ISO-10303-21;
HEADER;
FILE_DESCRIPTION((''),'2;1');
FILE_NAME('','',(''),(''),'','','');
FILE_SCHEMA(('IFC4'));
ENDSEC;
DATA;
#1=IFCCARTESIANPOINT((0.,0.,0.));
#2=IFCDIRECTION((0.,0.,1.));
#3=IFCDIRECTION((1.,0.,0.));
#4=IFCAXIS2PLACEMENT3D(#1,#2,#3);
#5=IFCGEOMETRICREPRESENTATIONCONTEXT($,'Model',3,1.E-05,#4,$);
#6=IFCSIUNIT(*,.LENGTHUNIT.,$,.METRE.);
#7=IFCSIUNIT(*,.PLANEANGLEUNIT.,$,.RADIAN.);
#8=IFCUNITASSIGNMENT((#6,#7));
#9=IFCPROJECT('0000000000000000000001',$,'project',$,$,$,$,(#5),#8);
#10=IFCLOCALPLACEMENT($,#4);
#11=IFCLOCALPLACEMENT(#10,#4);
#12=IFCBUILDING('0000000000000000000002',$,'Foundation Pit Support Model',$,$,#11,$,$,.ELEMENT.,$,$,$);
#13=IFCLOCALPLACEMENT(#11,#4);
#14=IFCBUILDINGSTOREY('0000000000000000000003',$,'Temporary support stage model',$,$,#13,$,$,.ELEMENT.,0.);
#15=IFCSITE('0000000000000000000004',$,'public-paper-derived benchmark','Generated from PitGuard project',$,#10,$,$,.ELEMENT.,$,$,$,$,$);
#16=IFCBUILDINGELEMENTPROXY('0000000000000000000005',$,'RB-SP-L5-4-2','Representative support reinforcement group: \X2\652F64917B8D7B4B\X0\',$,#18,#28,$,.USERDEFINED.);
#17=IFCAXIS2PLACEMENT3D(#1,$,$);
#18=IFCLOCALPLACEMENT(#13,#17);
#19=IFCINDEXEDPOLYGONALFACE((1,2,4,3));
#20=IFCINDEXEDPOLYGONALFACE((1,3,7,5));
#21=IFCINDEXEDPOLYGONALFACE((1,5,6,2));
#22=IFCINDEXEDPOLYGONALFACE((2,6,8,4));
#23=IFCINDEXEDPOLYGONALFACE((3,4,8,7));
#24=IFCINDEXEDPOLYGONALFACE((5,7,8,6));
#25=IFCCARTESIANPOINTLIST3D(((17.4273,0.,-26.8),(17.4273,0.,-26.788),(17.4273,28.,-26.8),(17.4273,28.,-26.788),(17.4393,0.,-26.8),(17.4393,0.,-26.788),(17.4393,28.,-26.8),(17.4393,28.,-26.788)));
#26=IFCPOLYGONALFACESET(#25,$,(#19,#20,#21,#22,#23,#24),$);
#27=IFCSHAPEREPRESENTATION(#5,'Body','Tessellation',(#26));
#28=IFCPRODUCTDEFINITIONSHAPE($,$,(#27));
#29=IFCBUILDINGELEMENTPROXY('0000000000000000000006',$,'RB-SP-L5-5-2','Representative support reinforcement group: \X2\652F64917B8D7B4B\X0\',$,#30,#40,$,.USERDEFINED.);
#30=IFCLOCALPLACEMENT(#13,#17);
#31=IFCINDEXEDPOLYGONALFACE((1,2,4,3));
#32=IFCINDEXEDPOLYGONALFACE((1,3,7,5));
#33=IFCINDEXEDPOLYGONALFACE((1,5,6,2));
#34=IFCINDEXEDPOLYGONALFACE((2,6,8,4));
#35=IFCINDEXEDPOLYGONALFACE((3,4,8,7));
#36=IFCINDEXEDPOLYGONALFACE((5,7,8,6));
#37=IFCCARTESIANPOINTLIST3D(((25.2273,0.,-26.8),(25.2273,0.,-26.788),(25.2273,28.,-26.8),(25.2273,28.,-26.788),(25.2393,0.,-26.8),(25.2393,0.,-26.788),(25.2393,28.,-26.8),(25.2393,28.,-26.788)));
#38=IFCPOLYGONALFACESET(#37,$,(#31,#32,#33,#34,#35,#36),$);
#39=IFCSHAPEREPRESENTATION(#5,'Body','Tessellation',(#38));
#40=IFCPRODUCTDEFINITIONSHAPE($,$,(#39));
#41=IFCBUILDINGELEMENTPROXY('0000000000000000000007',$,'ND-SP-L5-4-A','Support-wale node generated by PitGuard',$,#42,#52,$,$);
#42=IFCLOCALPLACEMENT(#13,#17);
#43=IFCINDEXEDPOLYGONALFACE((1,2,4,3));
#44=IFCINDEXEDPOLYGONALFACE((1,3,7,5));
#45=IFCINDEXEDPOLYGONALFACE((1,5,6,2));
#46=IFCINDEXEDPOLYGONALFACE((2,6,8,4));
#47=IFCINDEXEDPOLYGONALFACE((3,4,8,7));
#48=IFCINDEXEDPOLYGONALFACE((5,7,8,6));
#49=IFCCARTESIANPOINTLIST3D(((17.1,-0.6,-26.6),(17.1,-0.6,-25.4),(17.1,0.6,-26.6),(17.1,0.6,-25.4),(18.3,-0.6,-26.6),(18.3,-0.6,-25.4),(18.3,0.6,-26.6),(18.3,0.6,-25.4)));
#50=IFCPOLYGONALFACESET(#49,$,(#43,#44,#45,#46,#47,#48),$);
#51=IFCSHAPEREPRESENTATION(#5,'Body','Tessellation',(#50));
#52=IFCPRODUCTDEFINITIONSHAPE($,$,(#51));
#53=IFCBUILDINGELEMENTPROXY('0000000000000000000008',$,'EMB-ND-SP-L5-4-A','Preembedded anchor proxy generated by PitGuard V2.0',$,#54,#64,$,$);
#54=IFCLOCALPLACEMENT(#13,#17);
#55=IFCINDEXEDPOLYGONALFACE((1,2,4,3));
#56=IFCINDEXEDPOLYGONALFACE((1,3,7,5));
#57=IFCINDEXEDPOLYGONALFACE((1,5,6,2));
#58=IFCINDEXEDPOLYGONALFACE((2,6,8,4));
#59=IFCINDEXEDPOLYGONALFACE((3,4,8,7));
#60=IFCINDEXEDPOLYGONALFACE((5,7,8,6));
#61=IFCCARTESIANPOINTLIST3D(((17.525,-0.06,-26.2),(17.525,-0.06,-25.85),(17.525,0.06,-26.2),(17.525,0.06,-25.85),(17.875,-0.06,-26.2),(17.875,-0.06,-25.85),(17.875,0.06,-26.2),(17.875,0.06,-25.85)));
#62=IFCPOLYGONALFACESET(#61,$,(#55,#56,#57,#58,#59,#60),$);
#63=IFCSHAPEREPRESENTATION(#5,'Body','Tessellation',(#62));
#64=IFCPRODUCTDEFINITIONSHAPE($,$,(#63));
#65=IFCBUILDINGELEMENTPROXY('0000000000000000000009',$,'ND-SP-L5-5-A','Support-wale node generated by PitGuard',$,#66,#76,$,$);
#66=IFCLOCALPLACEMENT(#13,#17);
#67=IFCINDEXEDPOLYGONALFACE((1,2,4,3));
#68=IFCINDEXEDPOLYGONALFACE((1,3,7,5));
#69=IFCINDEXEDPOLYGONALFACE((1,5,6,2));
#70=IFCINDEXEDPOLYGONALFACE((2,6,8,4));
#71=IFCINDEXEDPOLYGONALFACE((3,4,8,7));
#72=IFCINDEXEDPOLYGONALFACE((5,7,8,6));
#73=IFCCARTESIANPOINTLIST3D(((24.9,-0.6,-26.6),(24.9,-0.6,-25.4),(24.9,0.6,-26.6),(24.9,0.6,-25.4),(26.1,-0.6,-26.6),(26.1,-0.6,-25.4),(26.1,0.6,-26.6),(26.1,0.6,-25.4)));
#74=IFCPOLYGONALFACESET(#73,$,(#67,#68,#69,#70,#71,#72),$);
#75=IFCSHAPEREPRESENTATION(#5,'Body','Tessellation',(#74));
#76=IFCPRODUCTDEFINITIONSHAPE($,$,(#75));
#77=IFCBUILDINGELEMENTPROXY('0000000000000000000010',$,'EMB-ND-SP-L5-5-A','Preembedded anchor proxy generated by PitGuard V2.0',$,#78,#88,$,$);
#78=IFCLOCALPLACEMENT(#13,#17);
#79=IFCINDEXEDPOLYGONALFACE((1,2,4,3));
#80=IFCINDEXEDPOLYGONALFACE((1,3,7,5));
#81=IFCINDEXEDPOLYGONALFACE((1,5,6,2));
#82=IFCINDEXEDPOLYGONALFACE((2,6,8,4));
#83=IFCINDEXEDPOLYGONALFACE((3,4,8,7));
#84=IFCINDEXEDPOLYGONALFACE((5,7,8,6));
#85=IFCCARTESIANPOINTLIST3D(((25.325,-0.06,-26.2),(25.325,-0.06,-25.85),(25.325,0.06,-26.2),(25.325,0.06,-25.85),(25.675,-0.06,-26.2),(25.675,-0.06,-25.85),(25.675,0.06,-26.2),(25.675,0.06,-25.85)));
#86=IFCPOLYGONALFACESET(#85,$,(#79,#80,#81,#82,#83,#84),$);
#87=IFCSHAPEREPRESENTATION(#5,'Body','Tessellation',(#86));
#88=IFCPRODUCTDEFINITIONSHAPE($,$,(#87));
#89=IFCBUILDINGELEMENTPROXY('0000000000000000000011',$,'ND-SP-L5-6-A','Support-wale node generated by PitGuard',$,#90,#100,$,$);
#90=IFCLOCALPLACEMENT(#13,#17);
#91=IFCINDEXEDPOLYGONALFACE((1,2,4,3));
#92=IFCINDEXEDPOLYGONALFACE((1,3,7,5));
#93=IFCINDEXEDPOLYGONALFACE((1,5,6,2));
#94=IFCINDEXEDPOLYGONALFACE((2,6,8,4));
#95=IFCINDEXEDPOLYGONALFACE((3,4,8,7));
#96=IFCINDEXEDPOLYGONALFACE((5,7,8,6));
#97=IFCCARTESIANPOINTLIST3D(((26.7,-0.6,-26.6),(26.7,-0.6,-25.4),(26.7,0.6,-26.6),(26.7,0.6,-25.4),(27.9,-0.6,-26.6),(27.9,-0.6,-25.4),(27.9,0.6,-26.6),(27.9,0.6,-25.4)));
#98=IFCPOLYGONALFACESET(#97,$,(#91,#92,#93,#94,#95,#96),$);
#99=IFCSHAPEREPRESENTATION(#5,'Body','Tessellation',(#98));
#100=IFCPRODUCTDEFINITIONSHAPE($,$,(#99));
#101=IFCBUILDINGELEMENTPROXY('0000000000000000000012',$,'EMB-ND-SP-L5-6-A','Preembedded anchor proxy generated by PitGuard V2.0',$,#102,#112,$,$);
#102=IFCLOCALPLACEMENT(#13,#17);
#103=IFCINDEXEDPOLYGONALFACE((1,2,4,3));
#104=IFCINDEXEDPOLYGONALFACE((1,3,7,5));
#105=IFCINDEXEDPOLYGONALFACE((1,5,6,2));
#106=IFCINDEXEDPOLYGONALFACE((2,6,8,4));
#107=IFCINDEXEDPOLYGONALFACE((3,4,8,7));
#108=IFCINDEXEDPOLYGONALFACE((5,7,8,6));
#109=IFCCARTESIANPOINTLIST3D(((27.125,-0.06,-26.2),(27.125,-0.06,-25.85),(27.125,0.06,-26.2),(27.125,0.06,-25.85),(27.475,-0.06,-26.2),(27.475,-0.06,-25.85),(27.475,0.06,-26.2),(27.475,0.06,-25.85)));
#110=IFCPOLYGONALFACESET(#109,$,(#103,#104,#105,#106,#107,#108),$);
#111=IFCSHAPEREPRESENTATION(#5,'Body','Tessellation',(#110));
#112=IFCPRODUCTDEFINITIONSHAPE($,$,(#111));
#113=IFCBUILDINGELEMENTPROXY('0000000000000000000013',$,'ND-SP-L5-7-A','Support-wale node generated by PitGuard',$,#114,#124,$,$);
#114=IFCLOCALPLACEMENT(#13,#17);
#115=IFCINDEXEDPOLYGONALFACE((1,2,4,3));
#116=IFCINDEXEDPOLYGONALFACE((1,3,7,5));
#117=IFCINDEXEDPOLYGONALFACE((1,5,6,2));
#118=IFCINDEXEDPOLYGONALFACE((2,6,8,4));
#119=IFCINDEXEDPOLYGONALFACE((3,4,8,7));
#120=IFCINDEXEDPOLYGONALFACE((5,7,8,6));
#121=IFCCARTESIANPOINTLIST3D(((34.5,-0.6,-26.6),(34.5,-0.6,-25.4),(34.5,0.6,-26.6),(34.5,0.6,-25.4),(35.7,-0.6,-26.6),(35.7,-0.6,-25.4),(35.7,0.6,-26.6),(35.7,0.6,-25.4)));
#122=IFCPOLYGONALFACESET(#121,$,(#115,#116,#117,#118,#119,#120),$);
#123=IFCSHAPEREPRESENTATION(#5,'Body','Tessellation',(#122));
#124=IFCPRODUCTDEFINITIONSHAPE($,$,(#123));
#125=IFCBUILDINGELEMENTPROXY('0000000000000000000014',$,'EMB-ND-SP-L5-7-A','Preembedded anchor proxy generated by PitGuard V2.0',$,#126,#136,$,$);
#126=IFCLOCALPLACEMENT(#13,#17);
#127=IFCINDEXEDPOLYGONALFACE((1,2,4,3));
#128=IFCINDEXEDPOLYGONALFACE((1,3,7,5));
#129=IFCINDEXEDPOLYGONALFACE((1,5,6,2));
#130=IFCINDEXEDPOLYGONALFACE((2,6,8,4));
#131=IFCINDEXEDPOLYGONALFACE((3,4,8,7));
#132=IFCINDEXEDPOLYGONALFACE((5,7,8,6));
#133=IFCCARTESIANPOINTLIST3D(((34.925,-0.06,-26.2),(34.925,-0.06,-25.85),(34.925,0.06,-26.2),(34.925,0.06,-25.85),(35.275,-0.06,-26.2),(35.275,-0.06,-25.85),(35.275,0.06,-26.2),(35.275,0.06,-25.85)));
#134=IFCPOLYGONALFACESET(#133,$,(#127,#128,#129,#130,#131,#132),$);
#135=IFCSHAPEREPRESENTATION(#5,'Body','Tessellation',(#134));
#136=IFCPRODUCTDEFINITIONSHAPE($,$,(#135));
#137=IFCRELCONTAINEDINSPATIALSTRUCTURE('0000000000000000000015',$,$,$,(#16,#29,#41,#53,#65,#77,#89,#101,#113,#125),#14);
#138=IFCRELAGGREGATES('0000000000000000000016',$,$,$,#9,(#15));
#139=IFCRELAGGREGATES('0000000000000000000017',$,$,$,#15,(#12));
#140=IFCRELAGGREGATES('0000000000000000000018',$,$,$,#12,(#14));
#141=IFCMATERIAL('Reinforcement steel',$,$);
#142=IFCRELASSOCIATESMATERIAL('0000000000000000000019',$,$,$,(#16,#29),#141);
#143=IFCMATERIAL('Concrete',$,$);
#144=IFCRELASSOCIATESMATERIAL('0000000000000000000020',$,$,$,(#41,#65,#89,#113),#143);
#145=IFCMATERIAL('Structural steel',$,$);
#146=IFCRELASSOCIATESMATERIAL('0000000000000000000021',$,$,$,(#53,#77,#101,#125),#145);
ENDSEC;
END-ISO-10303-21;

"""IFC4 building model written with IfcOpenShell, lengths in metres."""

from ifc_helpers import new_model, si_unit, frame, origin_with_axes, origin_2d, place, context, project, spatial, rectangle, extrude, material, element, save


model = new_model("IFC4")

# Units and contexts
model_context = context("Model", 3, precision=1e-05, world=origin_with_axes())
ifc_project = project(units=[si_unit("LENGTHUNIT", "METRE"), si_unit("PLANEANGLEUNIT", "RADIAN")], contexts=[model_context])

# Site, building, storey
site_placement = place(None, origin_with_axes())
site = spatial("IfcSite", under=ifc_project, at=site_placement, Name="public-paper-derived benchmark", Description="Generated from PitGuard project", CompositionType="ELEMENT")
building_placement = place(site_placement, origin_with_axes())
building = spatial("IfcBuilding", under=site, at=building_placement, Name="Foundation Pit Support Model", CompositionType="ELEMENT")
storey_placement = place(building_placement, origin_with_axes())
storey = spatial("IfcBuildingStorey", under=building, at=storey_placement, Name="Temporary support stage model", CompositionType="ELEMENT", Elevation=0.0)

# Shared definitions
ifc_material_1 = material(Name="Structural steel")

# Shared definitions
ifc_material_2 = material(Name="Concrete")

# Building element proxies
ifc_material_3 = material(Name="Reinforcement steel")
for number, where, z_axis, x_axis, name in (
    (1, (17.4333, 14.0, -26.8), (0.0, 0.0, 1.0), (0.0, 1.0, 0.0), "RB-SP-L5-4-2"),
    (2, (25.2333, 14.0, -26.8), (0.0, 0.0, 1.0), (0.0, 1.0, 0.0), "RB-SP-L5-5-2"),
):
    element("IfcBuildingElementProxy", number, at=place(storey_placement, frame(where, z_axis=z_axis, x_axis=x_axis)), inside=storey, material=ifc_material_3, Name=name, Description="Representative support reinforcement group: 支撑箍筋", PredefinedType="USERDEFINED", context=model_context, shape_type="SweptSolid", body=[
        extrude(rectangle(XDim=28.0, YDim=0.012, at=origin_2d()), origin_with_axes(), (0.0, 0.0, 1.0), 0.012),
    ])
proxy_1_placement = place(storey_placement, frame((17.7, 0.0, -26.6), z_axis=(0.0, 0.0, 1.0), x_axis=(1.0, 0.0, 0.0)))
element("IfcBuildingElementProxy", 3, at=proxy_1_placement, inside=storey, material=ifc_material_2, Name="ND-SP-L5-4-A", Description="Support-wale node generated by PitGuard", context=model_context, shape_type="SweptSolid", body=[
    extrude(rectangle(XDim=1.2, YDim=1.2, at=origin_2d()), origin_with_axes(), (0.0, 0.0, 1.0), 1.2),
])
proxy_2_placement = place(storey_placement, frame((17.7, 0.0, -26.2), z_axis=(0.0, 0.0, 1.0), x_axis=(1.0, 0.0, 0.0)))
element("IfcBuildingElementProxy", 4, at=proxy_2_placement, inside=storey, material=ifc_material_1, Name="EMB-ND-SP-L5-4-A", Description="Preembedded anchor proxy generated by PitGuard V2.0", context=model_context, shape_type="SweptSolid", body=[
    extrude(rectangle(XDim=0.35, YDim=0.12, at=origin_2d()), origin_with_axes(), (0.0, 0.0, 1.0), 0.35),
])
proxy_3_placement = place(storey_placement, frame((25.5, 0.0, -26.6), z_axis=(0.0, 0.0, 1.0), x_axis=(1.0, 0.0, 0.0)))
element("IfcBuildingElementProxy", 5, at=proxy_3_placement, inside=storey, material=ifc_material_2, Name="ND-SP-L5-5-A", Description="Support-wale node generated by PitGuard", context=model_context, shape_type="SweptSolid", body=[
    extrude(rectangle(XDim=1.2, YDim=1.2, at=origin_2d()), origin_with_axes(), (0.0, 0.0, 1.0), 1.2),
])
proxy_4_placement = place(storey_placement, frame((25.5, 0.0, -26.2), z_axis=(0.0, 0.0, 1.0), x_axis=(1.0, 0.0, 0.0)))
element("IfcBuildingElementProxy", 6, at=proxy_4_placement, inside=storey, material=ifc_material_1, Name="EMB-ND-SP-L5-5-A", Description="Preembedded anchor proxy generated by PitGuard V2.0", context=model_context, shape_type="SweptSolid", body=[
    extrude(rectangle(XDim=0.35, YDim=0.12, at=origin_2d()), origin_with_axes(), (0.0, 0.0, 1.0), 0.35),
])
proxy_5_placement = place(storey_placement, frame((27.3, 0.0, -26.6), z_axis=(0.0, 0.0, 1.0), x_axis=(1.0, 0.0, 0.0)))
element("IfcBuildingElementProxy", 7, at=proxy_5_placement, inside=storey, material=ifc_material_2, Name="ND-SP-L5-6-A", Description="Support-wale node generated by PitGuard", context=model_context, shape_type="SweptSolid", body=[
    extrude(rectangle(XDim=1.2, YDim=1.2, at=origin_2d()), origin_with_axes(), (0.0, 0.0, 1.0), 1.2),
])
proxy_6_placement = place(storey_placement, frame((27.3, 0.0, -26.2), z_axis=(0.0, 0.0, 1.0), x_axis=(1.0, 0.0, 0.0)))
element("IfcBuildingElementProxy", 8, at=proxy_6_placement, inside=storey, material=ifc_material_1, Name="EMB-ND-SP-L5-6-A", Description="Preembedded anchor proxy generated by PitGuard V2.0", context=model_context, shape_type="SweptSolid", body=[
    extrude(rectangle(XDim=0.35, YDim=0.12, at=origin_2d()), origin_with_axes(), (0.0, 0.0, 1.0), 0.35),
])
proxy_7_placement = place(storey_placement, frame((35.1, 0.0, -26.6), z_axis=(0.0, 0.0, 1.0), x_axis=(1.0, 0.0, 0.0)))
element("IfcBuildingElementProxy", 9, at=proxy_7_placement, inside=storey, material=ifc_material_2, Name="ND-SP-L5-7-A", Description="Support-wale node generated by PitGuard", context=model_context, shape_type="SweptSolid", body=[
    extrude(rectangle(XDim=1.2, YDim=1.2, at=origin_2d()), origin_with_axes(), (0.0, 0.0, 1.0), 1.2),
])
proxy_8_placement = place(storey_placement, frame((35.1, 0.0, -26.2), z_axis=(0.0, 0.0, 1.0), x_axis=(1.0, 0.0, 0.0)))
element("IfcBuildingElementProxy", 10, at=proxy_8_placement, inside=storey, material=ifc_material_1, Name="EMB-ND-SP-L5-7-A", Description="Preembedded anchor proxy generated by PitGuard V2.0", context=model_context, shape_type="SweptSolid", body=[
    extrude(rectangle(XDim=0.35, YDim=0.12, at=origin_2d()), origin_with_axes(), (0.0, 0.0, 1.0), 0.35),
])

save(model, "model.ifc")
